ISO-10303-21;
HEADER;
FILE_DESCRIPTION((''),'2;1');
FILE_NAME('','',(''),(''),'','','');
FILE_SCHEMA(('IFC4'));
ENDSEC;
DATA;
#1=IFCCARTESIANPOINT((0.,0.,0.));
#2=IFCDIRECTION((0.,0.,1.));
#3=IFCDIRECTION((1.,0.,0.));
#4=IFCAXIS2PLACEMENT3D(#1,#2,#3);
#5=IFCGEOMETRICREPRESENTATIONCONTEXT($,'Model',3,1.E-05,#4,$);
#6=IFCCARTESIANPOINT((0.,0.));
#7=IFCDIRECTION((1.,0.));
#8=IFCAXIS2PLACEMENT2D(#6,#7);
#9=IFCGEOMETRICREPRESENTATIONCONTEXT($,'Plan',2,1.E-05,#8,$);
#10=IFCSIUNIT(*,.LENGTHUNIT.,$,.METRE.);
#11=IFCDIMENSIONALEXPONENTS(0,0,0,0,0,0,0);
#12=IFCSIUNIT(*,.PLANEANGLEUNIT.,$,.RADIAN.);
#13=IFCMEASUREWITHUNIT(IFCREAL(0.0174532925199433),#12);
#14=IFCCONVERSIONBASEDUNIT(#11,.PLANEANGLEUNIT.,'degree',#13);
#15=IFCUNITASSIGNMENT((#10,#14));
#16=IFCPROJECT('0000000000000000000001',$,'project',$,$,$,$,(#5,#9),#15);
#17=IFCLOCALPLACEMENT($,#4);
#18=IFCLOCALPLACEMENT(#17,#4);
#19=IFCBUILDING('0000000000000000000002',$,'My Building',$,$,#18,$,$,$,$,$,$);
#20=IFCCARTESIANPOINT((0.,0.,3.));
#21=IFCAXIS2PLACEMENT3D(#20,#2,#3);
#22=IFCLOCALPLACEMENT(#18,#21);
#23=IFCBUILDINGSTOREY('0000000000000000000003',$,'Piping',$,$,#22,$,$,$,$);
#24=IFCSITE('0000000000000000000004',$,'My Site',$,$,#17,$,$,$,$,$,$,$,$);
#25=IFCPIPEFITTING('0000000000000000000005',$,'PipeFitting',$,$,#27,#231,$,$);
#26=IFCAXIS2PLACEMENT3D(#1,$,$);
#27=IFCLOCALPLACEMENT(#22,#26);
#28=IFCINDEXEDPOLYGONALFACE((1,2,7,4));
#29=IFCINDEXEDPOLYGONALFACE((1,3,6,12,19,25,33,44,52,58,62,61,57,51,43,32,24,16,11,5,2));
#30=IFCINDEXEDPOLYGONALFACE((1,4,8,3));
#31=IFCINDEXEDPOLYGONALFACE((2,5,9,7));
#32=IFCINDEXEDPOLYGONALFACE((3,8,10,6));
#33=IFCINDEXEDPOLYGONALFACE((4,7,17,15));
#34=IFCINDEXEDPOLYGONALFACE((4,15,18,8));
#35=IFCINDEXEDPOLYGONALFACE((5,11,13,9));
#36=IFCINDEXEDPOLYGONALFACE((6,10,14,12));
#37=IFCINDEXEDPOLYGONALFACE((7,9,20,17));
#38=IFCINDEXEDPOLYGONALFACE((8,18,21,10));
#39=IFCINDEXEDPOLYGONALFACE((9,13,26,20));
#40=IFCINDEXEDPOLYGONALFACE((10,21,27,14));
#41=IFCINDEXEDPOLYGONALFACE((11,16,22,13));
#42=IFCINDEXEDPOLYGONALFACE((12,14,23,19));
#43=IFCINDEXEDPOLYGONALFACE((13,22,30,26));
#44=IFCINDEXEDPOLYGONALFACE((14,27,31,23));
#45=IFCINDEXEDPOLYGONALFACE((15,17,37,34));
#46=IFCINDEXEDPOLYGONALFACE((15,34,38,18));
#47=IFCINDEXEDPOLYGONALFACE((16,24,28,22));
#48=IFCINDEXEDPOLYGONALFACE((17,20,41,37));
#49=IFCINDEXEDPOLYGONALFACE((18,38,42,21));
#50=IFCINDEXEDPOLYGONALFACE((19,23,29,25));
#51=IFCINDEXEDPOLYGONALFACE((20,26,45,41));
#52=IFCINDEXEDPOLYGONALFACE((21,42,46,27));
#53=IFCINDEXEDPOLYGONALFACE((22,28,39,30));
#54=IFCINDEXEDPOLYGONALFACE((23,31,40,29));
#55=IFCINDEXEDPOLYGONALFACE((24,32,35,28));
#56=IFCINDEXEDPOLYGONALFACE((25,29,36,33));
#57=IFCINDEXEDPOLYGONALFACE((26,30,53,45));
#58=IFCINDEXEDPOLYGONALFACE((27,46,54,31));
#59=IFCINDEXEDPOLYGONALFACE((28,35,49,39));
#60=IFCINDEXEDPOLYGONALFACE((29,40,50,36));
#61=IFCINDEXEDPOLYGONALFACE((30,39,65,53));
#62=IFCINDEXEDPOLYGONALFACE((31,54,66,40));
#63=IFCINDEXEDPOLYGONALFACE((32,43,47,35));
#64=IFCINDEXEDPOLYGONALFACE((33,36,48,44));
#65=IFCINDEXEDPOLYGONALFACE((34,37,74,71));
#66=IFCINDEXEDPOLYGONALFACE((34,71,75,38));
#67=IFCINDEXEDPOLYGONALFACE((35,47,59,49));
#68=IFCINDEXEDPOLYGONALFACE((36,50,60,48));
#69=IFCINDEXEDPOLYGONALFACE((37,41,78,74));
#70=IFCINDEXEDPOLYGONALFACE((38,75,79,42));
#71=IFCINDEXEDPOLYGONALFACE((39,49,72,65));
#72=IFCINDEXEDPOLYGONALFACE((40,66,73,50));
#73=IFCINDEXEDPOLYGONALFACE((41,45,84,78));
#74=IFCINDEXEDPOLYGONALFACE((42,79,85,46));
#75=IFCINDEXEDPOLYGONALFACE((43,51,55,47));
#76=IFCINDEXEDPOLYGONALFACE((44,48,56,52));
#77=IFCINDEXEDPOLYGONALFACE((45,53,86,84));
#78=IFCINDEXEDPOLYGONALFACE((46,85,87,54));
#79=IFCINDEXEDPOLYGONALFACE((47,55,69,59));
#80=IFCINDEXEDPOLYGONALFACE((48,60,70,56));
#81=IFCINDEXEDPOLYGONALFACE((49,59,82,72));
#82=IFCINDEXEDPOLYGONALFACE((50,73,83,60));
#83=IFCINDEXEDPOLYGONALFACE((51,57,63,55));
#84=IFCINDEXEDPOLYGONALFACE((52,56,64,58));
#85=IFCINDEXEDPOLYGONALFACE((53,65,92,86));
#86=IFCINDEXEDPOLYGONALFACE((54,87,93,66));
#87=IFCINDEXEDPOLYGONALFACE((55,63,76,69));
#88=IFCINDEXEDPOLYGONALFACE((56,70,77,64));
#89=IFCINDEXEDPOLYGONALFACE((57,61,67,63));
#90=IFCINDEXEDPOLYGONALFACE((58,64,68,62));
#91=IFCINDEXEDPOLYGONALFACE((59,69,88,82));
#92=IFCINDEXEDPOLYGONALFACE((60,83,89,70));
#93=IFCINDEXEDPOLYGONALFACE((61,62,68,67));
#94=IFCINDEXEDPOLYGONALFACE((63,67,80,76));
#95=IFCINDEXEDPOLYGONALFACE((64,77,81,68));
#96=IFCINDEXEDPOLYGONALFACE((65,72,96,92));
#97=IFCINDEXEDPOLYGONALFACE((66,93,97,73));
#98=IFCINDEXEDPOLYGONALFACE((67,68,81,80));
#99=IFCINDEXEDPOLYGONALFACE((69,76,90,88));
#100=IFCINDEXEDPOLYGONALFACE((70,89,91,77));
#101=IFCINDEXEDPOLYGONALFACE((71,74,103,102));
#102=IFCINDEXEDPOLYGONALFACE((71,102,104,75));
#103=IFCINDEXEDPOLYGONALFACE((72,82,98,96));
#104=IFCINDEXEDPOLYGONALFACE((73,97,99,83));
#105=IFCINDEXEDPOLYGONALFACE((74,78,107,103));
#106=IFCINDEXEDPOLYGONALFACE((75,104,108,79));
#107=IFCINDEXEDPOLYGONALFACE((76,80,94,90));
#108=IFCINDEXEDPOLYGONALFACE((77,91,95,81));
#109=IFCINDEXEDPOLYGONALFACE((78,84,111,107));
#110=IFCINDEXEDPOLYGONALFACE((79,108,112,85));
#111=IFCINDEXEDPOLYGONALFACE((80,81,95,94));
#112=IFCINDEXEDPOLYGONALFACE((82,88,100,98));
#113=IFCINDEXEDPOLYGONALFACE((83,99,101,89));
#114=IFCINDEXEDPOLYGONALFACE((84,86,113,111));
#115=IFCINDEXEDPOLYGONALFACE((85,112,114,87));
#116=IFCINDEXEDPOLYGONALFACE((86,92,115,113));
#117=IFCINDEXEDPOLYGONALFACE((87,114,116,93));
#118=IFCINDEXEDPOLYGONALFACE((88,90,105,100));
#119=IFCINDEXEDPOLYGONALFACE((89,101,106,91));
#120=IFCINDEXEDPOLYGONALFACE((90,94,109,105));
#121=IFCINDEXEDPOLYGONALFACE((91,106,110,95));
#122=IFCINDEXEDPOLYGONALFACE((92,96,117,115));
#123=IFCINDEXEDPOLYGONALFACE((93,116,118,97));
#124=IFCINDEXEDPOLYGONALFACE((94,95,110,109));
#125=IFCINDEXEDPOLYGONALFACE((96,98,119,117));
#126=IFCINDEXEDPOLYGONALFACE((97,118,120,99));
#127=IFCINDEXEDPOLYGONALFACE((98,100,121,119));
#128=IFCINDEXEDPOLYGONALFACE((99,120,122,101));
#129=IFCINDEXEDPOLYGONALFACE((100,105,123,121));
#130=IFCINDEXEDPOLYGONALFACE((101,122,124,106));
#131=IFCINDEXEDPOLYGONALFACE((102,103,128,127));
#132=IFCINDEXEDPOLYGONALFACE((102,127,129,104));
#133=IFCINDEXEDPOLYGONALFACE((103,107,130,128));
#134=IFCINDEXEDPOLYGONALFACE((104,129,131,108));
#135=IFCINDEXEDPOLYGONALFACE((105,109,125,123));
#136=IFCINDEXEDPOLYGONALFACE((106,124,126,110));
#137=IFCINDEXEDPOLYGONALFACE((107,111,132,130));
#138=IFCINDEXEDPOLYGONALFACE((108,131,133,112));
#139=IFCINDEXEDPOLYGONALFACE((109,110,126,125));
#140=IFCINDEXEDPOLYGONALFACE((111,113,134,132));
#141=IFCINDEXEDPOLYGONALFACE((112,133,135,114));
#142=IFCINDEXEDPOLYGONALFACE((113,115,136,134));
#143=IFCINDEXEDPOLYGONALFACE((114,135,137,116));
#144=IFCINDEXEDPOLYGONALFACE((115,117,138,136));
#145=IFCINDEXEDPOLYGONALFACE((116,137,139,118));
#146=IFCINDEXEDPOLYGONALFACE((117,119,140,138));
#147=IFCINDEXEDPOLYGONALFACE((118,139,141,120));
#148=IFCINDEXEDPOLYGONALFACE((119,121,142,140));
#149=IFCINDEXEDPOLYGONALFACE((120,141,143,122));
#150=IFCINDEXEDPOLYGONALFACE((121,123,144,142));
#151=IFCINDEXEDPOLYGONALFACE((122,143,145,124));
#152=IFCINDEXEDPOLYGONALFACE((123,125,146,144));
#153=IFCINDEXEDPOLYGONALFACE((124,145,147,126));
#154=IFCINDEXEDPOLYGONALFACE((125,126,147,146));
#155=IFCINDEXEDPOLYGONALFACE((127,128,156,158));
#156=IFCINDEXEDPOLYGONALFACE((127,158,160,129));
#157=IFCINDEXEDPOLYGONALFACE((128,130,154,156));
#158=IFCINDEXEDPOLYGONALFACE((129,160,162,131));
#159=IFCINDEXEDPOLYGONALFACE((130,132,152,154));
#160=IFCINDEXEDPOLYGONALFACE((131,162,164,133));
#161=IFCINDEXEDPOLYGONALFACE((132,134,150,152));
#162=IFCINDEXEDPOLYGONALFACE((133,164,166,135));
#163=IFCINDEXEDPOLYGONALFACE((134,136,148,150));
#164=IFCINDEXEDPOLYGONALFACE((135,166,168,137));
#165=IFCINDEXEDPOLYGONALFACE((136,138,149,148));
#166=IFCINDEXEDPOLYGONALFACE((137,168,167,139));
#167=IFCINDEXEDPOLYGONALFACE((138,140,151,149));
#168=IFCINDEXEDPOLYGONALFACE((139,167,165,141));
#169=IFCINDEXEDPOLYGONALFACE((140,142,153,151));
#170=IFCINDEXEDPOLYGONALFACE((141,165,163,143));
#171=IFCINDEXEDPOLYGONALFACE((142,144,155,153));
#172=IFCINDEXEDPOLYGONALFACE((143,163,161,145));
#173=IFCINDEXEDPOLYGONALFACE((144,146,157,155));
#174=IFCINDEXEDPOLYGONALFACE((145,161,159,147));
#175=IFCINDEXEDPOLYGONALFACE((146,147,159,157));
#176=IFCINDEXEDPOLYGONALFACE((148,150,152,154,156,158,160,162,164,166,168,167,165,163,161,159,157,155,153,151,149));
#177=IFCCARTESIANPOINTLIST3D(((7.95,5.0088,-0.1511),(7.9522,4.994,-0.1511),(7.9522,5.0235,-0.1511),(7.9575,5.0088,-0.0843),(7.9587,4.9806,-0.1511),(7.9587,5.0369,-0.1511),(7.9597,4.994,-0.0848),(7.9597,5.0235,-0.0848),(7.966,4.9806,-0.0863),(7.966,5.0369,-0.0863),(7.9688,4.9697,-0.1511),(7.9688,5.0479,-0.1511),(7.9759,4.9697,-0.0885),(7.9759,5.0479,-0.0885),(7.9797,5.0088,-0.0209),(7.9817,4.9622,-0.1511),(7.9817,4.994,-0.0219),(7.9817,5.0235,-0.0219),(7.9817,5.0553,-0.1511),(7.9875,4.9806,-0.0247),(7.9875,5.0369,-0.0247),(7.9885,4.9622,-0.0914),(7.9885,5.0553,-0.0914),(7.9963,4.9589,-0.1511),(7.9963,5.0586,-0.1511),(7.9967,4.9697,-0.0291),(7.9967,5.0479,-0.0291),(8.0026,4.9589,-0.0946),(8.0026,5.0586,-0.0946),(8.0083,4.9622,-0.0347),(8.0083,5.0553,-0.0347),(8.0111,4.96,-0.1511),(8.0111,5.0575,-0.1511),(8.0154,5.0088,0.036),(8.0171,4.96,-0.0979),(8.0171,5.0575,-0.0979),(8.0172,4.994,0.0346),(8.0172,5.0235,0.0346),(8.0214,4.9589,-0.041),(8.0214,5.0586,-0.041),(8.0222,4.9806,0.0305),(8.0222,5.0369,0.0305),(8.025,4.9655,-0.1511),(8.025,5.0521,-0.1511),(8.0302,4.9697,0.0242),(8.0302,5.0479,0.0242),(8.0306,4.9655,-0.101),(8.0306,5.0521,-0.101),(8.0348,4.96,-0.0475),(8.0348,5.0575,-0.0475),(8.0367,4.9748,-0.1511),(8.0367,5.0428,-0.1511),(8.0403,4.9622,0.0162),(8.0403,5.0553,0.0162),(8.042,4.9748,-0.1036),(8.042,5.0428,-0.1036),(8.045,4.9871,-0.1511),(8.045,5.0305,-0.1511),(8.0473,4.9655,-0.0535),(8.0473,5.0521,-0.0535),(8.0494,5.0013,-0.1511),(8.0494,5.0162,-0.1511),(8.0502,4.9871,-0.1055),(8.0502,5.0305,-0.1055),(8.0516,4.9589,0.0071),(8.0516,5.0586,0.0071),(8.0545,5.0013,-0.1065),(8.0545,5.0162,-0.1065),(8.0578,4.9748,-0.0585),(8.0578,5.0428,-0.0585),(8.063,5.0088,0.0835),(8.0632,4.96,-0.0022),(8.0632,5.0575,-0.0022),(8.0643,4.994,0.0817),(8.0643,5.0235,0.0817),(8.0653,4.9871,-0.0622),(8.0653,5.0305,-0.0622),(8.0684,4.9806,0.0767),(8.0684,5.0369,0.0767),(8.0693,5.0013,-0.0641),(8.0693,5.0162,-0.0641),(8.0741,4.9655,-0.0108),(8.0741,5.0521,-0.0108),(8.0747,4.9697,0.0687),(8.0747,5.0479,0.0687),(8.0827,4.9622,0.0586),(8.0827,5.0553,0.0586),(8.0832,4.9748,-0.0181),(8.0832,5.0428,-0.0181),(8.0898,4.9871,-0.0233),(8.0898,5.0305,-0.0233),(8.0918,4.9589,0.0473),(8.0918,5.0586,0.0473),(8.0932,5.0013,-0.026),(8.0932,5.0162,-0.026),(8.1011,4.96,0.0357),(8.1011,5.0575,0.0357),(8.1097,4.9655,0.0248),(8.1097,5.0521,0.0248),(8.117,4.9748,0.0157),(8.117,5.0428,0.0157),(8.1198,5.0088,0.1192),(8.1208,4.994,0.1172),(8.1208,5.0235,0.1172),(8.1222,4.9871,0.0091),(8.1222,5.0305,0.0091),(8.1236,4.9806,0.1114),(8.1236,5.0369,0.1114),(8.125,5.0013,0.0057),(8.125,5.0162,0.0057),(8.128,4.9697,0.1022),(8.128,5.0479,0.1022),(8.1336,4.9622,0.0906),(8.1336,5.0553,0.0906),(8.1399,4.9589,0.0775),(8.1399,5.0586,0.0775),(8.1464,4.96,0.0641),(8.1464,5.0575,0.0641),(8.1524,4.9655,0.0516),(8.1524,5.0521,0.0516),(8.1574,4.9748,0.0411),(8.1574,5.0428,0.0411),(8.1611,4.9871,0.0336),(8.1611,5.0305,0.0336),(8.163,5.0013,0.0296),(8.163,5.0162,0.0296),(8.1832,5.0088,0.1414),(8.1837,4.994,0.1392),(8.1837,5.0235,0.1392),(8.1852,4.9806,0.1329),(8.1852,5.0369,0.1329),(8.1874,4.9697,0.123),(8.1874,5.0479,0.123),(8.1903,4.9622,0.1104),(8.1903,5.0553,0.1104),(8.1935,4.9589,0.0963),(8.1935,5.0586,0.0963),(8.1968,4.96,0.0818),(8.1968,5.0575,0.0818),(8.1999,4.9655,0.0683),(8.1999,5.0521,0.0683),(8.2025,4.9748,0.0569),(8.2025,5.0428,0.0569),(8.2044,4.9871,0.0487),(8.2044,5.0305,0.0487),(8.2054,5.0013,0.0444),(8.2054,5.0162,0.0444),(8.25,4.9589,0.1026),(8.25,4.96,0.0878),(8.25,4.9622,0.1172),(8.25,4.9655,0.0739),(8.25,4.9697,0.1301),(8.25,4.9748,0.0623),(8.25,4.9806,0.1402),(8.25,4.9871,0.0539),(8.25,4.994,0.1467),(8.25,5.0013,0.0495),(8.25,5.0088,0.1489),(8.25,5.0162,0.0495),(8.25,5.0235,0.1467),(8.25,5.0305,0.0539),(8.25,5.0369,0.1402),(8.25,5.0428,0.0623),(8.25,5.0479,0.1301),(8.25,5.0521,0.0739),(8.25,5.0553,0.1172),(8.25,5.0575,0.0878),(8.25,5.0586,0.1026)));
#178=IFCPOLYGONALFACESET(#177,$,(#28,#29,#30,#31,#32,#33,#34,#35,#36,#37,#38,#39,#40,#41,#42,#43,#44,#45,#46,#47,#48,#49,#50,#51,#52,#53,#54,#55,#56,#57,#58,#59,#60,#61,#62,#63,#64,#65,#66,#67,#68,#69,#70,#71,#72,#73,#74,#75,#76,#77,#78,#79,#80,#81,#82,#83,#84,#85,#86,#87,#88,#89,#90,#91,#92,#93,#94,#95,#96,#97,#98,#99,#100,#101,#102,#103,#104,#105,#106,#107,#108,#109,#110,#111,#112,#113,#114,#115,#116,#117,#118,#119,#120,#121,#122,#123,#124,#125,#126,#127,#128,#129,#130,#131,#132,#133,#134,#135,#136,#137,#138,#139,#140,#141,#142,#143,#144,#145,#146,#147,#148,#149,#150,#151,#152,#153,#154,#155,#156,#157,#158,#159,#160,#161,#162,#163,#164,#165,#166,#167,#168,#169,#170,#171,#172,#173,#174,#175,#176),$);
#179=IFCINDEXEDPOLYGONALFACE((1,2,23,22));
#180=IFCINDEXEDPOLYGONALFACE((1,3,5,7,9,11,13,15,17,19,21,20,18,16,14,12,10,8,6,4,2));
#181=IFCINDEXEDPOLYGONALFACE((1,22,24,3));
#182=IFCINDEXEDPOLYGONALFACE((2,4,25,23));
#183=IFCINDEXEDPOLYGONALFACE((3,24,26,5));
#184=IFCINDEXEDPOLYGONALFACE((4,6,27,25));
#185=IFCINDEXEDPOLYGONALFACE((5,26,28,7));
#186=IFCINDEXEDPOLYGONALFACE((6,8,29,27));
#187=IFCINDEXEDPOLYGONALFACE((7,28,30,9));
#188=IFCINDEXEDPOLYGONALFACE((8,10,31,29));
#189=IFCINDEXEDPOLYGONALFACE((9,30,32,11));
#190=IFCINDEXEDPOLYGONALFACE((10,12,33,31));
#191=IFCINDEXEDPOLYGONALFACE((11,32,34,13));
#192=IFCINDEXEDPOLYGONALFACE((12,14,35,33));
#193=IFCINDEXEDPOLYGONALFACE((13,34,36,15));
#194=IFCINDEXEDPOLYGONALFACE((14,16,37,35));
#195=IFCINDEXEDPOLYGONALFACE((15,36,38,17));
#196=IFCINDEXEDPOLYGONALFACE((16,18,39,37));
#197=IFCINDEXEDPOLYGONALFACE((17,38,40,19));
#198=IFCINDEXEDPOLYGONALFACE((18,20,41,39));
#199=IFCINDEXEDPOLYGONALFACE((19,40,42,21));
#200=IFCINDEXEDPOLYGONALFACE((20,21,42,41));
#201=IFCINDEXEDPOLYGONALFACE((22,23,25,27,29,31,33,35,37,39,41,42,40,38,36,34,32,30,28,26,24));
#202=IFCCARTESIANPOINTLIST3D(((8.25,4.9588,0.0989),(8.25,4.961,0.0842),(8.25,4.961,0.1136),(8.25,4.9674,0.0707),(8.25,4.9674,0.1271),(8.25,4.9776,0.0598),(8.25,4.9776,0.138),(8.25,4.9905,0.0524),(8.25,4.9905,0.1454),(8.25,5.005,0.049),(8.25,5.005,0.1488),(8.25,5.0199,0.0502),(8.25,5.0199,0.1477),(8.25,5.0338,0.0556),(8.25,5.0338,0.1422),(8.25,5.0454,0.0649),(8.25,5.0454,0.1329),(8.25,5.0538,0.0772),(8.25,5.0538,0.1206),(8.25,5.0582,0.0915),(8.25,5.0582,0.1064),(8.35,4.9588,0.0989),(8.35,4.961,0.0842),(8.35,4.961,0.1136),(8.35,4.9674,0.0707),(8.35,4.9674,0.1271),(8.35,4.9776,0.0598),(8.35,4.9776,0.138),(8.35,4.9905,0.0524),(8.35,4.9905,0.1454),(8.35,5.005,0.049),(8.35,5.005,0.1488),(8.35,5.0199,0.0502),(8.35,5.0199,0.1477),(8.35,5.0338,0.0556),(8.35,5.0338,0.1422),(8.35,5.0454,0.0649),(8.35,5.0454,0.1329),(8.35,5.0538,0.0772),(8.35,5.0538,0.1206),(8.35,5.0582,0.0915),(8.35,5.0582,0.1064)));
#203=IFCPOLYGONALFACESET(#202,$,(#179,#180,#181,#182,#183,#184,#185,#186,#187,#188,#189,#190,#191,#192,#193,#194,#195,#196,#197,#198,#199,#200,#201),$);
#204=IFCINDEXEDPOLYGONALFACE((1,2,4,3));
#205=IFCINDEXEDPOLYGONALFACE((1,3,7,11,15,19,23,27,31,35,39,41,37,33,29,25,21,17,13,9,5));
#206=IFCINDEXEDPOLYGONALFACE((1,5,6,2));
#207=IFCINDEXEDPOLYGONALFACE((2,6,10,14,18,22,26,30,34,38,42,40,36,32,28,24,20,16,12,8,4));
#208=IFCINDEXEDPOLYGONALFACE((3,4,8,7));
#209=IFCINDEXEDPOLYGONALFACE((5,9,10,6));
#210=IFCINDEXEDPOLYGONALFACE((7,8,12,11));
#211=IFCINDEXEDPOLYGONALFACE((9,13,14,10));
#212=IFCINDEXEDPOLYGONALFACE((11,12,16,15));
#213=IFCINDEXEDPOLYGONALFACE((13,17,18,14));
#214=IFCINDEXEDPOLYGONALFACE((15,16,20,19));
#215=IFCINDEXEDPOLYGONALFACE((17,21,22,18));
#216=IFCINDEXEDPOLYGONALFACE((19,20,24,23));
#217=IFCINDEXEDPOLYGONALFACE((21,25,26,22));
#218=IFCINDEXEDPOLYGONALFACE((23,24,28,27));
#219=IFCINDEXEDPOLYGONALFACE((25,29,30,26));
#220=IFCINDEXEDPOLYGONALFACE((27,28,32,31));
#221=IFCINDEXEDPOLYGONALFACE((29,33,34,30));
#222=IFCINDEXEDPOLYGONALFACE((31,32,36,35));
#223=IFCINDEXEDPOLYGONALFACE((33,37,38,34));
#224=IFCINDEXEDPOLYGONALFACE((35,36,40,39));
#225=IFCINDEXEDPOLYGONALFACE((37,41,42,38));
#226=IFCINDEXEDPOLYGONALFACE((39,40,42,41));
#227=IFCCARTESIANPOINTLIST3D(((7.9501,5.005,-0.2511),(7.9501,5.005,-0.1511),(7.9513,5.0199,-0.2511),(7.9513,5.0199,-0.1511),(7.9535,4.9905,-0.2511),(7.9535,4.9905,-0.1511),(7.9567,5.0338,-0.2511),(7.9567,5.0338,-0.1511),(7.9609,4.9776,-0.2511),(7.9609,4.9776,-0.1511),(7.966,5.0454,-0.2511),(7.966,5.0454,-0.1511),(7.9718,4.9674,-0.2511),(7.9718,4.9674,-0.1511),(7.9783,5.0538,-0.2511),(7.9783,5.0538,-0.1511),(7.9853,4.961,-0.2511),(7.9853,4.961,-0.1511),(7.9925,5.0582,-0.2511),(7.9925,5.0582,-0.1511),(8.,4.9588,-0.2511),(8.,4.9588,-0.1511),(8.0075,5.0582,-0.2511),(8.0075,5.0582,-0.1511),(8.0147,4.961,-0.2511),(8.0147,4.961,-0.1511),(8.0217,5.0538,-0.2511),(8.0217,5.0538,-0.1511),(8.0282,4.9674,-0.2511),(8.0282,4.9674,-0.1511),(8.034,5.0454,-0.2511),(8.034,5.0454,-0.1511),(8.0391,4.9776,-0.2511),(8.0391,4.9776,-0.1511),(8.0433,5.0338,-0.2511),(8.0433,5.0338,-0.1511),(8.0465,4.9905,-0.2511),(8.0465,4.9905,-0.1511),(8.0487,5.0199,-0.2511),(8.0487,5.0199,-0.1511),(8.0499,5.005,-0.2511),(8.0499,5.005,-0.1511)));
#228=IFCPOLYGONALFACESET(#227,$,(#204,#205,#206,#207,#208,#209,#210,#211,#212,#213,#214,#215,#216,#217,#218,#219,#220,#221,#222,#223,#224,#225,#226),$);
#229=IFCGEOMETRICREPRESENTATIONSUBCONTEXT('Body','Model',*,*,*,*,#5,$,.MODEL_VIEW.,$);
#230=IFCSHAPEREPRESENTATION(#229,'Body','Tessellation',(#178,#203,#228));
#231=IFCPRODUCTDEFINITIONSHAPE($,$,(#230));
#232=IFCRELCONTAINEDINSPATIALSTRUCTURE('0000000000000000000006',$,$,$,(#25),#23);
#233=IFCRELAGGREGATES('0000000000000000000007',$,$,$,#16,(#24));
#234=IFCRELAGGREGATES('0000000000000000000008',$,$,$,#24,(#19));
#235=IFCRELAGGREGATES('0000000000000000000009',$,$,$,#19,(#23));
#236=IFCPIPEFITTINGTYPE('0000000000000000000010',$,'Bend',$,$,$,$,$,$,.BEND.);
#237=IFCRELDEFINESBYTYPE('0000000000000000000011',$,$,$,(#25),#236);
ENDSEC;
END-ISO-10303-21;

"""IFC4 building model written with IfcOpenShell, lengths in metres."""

from ifc_helpers import new_model, entity, si_unit, converted_unit, frame, origin_with_axes, origin_2d_with_axis, place, context, subcontext, project, spatial, circle, extrude, source, transform, mapped, type_object, type_shapes, element, save


model = new_model("IFC4")

# Units and contexts
model_context = context("Model", 3, precision=1e-05, world=origin_with_axes())
plan_context = context("Plan", 2, precision=1e-05, world=origin_2d_with_axis())
body_context = subcontext(model_context, "Body", "Model", "MODEL_VIEW")
ifc_project = project(units=[si_unit("LENGTHUNIT", "METRE"), converted_unit("PLANEANGLEUNIT", "degree", entity("IfcReal", 0.0174532925199433), si_unit("PLANEANGLEUNIT", "RADIAN"), dimensions=[0, 0, 0, 0, 0, 0, 0])], contexts=[model_context, plan_context])

# Site, building, storey
site_placement = place(None, origin_with_axes())
site = spatial("IfcSite", under=ifc_project, at=site_placement, Name="My Site")
building_placement = place(site_placement, origin_with_axes())
building = spatial("IfcBuilding", under=site, at=building_placement, Name="My Building")
storey_placement = place(building_placement, frame((0.0, 0.0, 3.0), z_axis=(0.0, 0.0, 1.0), x_axis=(1.0, 0.0, 0.0)))
storey = spatial("IfcBuildingStorey", under=building, at=storey_placement, Name="Piping")

# Pipe fitting
pipe_fitting_type_1 = type_object("IfcPipeFittingType", Name="Bend", PredefinedType="BEND")
shared_shape_1 = source(origin_with_axes(), body_context, "Body", "SolidModel", [
    entity("IfcSweptDiskSolid", entity("IfcIndexedPolyCurve", entity("IfcCartesianPointList3D", [[0.0, 0.0, 0.1], [0.0, -0.0732, 0.2768], [0.0, -0.25, 0.35]]), [entity("IfcArcIndex", [1, 2, 3])]), 0.05),
    extrude(circle(Radius=0.05), origin_with_axes(), (0.0, 0.0, 1.0), 0.1),
    extrude(circle(Radius=0.05), frame((0.0, -0.25, 0.35), z_axis=(0.0, -1.0, 0.0), x_axis=(1.0, 0.0, 0.0)), (0.0, 0.0, 1.0), 0.1),
])
type_shapes(pipe_fitting_type_1, [shared_shape_1])
for number, where, z_axis, x_axis, name in (
    (1, (8.35, 5.0088, 0.0989), (-1.0, 0.0, 0.0), (0.0, -1.0, 0.0), "PipeFitting"),
):
    element("IfcPipeFitting", number, at=place(storey_placement, frame(where, z_axis=z_axis, x_axis=x_axis)), inside=storey, type_object=pipe_fitting_type_1, Name=name, context=body_context, shape_type="MappedRepresentation", body=[
        mapped(shared_shape_1, transform((0.0, 0.0, 0.0), x_axis=(1.0, 0.0, 0.0), y_axis=(0.0, 1.0, 0.0), z_axis=(0.0, 0.0, 1.0), scale=1.0)),
    ])

save(model, "model.ifc")
